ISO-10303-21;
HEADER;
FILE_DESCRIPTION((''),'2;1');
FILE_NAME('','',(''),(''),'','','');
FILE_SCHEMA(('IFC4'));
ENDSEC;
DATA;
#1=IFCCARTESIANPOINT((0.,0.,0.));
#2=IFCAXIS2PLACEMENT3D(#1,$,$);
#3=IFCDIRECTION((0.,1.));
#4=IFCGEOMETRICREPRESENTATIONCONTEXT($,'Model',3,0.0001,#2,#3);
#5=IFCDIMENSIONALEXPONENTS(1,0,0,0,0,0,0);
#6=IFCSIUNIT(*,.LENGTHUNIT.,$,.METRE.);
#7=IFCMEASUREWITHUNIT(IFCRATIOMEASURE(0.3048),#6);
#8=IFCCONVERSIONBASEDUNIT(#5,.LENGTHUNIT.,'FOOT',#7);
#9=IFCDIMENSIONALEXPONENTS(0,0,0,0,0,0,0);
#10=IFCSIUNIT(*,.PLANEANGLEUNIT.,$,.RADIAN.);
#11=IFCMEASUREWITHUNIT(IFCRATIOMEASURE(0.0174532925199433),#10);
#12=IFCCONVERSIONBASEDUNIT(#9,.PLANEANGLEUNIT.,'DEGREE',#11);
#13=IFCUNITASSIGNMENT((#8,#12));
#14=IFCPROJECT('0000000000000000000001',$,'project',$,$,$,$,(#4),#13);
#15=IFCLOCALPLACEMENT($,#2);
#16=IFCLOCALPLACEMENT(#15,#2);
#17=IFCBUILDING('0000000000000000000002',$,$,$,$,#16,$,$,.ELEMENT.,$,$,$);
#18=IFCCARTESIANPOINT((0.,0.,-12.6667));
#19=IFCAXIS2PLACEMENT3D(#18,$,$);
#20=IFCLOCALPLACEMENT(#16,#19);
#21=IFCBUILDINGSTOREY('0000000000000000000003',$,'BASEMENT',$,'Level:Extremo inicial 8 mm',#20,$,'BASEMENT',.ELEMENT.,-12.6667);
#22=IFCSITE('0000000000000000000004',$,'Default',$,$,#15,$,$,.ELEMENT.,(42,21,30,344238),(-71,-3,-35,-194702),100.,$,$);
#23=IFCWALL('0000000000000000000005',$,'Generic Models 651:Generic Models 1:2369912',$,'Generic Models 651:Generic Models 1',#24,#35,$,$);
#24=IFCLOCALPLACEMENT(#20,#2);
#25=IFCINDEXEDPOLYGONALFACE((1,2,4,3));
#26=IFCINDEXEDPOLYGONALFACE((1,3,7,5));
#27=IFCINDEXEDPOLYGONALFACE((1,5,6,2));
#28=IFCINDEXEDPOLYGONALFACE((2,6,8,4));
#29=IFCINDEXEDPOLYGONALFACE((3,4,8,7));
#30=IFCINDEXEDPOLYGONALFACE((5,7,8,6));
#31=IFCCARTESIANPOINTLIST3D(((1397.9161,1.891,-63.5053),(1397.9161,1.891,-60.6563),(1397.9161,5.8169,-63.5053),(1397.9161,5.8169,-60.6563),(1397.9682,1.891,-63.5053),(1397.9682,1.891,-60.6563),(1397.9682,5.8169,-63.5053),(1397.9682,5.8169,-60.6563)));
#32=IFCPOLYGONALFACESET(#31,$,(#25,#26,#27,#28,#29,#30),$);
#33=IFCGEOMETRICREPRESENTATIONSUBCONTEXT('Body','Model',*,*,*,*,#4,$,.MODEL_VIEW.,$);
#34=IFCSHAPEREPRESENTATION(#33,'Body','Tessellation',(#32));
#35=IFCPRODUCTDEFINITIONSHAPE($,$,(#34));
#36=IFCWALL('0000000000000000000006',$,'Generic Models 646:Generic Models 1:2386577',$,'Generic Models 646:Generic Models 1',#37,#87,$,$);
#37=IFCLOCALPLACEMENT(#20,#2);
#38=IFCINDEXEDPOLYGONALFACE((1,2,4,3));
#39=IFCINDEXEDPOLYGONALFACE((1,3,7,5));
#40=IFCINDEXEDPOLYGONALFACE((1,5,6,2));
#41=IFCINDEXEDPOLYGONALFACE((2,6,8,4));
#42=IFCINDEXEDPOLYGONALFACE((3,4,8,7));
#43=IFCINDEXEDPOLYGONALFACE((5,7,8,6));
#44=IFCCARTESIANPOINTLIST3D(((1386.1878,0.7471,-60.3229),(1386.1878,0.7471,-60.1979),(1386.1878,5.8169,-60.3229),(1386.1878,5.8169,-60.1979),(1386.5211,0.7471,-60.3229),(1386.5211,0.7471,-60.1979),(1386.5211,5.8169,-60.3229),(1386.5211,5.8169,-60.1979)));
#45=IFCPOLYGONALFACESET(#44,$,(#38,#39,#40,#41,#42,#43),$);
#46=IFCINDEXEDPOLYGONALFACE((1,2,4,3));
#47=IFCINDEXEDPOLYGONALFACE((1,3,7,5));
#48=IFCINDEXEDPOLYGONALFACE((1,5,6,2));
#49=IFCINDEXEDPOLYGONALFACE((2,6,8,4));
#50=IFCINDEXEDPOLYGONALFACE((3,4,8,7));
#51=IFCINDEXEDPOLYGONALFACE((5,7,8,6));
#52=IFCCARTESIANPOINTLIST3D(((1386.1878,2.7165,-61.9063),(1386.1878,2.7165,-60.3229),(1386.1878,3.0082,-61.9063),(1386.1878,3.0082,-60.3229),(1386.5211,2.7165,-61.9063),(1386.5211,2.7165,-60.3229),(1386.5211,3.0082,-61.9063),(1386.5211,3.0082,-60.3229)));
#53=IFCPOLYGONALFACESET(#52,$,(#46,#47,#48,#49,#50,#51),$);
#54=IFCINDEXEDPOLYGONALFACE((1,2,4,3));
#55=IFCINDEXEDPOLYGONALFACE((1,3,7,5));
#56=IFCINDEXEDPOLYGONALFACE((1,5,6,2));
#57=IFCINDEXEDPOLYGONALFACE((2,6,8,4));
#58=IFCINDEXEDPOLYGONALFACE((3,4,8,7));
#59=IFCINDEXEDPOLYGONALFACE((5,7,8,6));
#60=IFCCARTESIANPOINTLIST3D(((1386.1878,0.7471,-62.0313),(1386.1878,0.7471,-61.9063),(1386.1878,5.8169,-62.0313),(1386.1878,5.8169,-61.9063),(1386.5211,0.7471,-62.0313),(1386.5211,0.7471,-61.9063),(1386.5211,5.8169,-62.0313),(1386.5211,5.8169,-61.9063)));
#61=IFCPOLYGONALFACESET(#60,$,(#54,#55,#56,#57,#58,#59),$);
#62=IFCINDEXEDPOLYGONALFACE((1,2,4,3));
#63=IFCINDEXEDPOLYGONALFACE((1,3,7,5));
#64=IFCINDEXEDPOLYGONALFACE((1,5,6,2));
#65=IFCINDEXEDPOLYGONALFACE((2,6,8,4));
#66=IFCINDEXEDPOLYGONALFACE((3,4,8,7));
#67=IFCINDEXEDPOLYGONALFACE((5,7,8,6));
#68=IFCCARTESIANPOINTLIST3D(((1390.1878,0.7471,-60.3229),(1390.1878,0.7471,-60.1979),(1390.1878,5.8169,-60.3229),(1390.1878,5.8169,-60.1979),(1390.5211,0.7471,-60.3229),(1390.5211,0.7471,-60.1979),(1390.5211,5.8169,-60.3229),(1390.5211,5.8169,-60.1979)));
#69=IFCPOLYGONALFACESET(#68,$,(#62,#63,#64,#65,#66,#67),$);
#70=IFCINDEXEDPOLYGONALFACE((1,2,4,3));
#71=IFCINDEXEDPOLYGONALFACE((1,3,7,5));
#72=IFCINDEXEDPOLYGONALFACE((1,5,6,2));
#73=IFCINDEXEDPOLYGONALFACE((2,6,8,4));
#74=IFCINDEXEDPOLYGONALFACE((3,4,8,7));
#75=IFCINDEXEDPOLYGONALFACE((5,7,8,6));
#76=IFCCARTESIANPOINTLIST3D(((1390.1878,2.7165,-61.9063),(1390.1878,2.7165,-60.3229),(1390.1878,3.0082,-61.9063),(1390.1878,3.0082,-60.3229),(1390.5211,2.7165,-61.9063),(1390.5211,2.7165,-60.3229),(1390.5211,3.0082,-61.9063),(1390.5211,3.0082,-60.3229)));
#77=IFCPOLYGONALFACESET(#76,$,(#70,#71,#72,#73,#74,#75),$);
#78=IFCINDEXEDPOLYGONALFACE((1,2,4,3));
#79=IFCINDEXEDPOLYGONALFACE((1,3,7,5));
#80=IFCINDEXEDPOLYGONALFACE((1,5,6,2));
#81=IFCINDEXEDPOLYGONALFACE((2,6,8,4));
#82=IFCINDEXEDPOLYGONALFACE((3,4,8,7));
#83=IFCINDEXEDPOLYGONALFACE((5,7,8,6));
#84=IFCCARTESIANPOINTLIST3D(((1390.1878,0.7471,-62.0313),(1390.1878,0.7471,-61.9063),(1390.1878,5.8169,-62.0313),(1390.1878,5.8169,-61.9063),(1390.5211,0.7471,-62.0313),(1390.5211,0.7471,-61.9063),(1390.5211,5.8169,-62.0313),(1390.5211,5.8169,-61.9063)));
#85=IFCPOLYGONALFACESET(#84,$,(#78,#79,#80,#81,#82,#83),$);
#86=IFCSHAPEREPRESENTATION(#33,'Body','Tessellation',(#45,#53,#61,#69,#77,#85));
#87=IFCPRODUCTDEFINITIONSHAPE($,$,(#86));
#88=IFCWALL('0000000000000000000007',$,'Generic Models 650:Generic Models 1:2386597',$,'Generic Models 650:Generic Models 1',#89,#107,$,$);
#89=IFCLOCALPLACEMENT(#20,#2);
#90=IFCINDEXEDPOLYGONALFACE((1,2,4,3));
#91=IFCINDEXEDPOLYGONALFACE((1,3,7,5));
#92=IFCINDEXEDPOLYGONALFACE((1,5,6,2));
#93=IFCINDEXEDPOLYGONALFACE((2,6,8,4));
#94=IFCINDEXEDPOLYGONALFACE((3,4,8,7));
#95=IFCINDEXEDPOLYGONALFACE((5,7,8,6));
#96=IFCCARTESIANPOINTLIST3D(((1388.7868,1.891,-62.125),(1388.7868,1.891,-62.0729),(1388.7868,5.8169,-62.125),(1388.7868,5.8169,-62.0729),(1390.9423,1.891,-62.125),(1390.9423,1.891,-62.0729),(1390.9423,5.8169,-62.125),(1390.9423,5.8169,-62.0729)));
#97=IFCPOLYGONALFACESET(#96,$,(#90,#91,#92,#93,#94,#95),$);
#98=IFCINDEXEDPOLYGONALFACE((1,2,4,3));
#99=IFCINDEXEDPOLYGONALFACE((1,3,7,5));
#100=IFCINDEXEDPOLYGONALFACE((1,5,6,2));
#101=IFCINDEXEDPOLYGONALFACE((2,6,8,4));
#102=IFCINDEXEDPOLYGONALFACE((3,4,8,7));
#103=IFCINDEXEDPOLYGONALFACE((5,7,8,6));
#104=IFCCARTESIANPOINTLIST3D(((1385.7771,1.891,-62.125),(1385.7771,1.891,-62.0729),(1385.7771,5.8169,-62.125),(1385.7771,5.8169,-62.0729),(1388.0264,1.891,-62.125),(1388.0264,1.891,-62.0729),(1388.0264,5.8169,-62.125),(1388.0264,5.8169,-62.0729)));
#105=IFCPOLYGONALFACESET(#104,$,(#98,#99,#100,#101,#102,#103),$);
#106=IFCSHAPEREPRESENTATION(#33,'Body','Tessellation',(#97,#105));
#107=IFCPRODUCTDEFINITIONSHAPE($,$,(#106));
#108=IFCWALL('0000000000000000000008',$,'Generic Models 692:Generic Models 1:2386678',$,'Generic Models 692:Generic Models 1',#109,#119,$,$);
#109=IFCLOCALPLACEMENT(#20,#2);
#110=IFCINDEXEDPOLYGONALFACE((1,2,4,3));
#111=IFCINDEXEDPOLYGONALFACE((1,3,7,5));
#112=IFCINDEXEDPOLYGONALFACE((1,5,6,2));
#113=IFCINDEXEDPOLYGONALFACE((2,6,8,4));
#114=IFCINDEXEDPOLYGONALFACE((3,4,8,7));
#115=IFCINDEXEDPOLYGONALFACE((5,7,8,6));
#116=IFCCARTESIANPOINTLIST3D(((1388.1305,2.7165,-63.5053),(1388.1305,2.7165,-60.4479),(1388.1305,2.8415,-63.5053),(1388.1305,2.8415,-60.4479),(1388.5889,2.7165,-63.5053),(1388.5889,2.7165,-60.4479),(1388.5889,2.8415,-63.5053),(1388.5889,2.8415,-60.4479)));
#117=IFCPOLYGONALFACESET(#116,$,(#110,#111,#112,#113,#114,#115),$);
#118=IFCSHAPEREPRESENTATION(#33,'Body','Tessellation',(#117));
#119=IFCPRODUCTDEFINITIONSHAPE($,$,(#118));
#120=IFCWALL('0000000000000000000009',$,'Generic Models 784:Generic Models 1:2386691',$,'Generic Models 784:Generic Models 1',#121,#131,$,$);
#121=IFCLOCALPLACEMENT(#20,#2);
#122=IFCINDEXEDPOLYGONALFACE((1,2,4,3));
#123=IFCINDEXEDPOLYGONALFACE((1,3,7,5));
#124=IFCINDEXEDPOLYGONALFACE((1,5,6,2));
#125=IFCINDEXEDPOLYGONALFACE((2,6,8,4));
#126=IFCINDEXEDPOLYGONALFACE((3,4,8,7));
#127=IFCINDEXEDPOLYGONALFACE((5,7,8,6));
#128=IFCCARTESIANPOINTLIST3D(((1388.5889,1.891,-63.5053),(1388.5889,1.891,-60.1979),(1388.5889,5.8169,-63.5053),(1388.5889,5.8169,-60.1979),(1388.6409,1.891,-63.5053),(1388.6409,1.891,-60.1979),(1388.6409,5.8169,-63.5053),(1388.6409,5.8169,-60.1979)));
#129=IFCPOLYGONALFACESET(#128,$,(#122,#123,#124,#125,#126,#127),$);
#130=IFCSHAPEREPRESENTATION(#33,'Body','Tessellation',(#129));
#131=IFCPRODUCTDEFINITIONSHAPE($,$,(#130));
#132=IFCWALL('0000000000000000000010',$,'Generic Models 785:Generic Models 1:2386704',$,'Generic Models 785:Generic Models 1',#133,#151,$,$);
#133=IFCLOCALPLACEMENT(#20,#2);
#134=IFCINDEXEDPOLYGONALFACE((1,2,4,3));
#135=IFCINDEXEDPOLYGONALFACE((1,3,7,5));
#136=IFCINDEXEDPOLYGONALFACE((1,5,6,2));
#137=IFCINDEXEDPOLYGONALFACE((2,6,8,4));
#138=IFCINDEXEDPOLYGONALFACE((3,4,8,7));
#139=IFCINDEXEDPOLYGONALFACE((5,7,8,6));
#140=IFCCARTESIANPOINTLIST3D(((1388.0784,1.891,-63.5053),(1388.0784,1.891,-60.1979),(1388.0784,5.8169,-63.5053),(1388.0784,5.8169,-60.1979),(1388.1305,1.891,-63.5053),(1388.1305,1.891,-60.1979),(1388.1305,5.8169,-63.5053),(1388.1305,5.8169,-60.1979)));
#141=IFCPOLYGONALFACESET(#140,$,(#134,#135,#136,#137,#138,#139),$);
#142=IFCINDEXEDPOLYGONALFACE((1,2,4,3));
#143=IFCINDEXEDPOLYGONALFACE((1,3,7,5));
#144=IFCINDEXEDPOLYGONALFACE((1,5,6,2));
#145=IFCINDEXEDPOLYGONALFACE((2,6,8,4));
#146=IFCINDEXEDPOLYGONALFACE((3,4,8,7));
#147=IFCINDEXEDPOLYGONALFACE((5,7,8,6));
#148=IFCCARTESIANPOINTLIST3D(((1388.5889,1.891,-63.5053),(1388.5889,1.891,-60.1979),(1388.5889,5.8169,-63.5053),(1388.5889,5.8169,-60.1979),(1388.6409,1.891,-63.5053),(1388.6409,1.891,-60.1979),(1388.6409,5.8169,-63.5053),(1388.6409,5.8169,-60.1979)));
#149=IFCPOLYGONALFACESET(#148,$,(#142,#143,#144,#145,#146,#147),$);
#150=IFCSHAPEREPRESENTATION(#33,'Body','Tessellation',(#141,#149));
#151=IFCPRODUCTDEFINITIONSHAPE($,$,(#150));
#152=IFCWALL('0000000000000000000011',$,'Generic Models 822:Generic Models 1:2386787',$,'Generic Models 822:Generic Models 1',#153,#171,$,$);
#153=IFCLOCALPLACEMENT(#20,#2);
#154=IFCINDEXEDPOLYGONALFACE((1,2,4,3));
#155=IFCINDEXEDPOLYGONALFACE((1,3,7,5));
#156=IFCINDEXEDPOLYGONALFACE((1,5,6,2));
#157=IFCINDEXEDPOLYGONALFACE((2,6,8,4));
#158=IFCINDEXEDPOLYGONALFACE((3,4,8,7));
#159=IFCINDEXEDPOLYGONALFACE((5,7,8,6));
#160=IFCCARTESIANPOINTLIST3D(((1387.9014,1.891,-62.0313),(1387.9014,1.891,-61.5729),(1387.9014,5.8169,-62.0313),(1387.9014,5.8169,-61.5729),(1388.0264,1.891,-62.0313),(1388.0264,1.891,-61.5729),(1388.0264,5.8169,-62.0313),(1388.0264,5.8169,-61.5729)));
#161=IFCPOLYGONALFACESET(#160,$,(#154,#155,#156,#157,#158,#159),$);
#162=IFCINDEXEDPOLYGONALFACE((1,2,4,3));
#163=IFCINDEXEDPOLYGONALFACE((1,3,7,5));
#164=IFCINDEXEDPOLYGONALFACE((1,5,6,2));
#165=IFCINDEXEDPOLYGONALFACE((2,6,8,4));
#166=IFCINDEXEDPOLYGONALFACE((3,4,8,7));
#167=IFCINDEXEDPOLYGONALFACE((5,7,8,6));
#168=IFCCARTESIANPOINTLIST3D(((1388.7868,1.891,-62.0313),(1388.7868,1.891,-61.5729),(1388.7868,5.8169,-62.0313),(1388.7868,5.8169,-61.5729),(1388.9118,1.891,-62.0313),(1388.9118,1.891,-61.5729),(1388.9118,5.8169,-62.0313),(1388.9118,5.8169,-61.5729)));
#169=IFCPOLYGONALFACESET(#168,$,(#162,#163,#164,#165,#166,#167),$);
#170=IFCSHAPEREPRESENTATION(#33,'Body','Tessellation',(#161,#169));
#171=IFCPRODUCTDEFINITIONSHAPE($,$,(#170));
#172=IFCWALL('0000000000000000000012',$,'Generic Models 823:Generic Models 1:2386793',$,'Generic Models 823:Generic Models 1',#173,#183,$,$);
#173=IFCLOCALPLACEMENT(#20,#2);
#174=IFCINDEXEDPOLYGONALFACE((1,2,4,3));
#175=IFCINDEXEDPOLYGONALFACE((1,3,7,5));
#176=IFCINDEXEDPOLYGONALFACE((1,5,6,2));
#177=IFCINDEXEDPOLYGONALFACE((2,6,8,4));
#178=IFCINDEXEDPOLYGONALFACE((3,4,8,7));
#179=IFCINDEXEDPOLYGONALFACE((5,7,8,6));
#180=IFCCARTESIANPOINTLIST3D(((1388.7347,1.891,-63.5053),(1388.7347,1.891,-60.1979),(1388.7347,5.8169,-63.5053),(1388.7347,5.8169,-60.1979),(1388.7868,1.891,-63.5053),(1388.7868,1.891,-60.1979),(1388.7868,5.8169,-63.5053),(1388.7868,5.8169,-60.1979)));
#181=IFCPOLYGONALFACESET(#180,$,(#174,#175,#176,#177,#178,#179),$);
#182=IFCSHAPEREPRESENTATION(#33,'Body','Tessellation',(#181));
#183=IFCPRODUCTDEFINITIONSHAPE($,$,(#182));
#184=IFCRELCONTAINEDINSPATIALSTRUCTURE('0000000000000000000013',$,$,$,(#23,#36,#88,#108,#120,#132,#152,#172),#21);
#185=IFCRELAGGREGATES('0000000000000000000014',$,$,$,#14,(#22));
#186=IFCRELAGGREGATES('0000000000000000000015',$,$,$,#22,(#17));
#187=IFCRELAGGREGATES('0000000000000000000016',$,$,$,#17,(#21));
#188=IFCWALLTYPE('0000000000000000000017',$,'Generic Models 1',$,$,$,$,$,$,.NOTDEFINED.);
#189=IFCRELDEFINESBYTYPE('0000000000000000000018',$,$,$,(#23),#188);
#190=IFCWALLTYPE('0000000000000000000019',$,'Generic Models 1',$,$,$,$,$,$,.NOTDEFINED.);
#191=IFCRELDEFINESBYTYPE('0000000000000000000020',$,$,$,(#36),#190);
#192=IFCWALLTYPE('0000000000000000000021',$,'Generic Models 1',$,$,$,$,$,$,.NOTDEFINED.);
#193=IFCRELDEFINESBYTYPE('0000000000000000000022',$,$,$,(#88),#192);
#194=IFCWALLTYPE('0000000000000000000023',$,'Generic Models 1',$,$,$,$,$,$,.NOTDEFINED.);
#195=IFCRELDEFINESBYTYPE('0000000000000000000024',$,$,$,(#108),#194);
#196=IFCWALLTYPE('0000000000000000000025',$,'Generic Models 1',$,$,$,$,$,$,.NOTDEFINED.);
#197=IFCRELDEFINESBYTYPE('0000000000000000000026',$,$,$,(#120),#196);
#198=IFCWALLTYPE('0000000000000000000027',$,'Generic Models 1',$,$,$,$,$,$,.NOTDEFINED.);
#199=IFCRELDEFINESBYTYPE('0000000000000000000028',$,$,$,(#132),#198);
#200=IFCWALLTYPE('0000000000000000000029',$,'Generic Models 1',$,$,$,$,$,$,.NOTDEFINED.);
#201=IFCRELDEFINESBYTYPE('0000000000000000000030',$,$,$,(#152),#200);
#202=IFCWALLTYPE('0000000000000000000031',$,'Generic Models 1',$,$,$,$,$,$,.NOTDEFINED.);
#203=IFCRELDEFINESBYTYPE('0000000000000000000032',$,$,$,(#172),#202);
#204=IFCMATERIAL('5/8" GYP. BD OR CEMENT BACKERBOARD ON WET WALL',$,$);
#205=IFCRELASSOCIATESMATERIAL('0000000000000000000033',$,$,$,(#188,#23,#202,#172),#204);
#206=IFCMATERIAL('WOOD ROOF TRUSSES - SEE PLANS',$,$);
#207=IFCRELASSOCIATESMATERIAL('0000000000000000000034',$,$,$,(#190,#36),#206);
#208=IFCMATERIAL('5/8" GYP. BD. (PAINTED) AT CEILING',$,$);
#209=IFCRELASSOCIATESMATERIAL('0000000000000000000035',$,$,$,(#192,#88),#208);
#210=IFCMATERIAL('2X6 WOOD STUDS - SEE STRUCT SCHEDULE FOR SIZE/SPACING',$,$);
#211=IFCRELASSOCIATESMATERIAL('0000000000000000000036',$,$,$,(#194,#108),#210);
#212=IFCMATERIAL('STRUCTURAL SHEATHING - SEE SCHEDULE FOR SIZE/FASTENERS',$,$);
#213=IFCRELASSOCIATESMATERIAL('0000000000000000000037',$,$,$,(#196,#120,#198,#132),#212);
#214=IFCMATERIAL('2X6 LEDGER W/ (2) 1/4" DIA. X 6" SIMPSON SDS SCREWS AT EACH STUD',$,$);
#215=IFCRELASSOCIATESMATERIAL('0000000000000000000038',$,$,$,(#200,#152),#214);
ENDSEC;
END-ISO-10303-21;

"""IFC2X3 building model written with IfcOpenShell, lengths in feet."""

from ifc_helpers import new_model, entity, si_unit, converted_unit, direction, frame, frame_2d, origin, place, context, subcontext, project, spatial, rectangle, extrude, material, type_object, element, save


model = new_model("IFC2X3")

# Units and contexts
model_context = context("Model", 3, precision=0.0001, world=origin(), true_north=direction((0.0, 1.0)))
body_context = subcontext(model_context, "Body", "Model", "MODEL_VIEW")
ifc_project = project(units=[converted_unit("LENGTHUNIT", "FOOT", entity("IfcRatioMeasure", 0.3048), si_unit("LENGTHUNIT", "METRE"), dimensions=[1, 0, 0, 0, 0, 0, 0]), converted_unit("PLANEANGLEUNIT", "DEGREE", entity("IfcRatioMeasure", 0.0174532925199433), si_unit("PLANEANGLEUNIT", "RADIAN"), dimensions=[0, 0, 0, 0, 0, 0, 0])], contexts=[model_context])

# Site, building, storey
site_placement = place(None, origin())
site = spatial("IfcSite", under=ifc_project, at=site_placement, Name="Default", CompositionType="ELEMENT", RefLatitude=(42, 21, 30, 344238), RefLongitude=(-71, -3, -35, -194702), RefElevation=100.0)
building_placement = place(site_placement, origin())
building = spatial("IfcBuilding", under=site, at=building_placement, CompositionType="ELEMENT")
storey_placement = place(building_placement, frame((0.0, 0.0, -12.6667)))
storey = spatial("IfcBuildingStorey", under=building, at=storey_placement, Name="BASEMENT", ObjectType="Level:Extremo inicial 8 mm", LongName="BASEMENT", CompositionType="ELEMENT", Elevation=-12.6667)

# Walls
ifc_material_1 = material(Name="2X6 WOOD STUDS - SEE STRUCT SCHEDULE FOR SIZE/SPACING")
ifc_material_2 = material(Name="5/8\" GYP. BD. (PAINTED) AT CEILING")
ifc_material_3 = material(Name="5/8\" GYP. BD OR CEMENT BACKERBOARD ON WET WALL")
wall_type_1 = type_object("IfcWallType", Name="Generic Models 1", PredefinedType="NOTDEFINED", material=ifc_material_3)
wall_1_placement = place(storey_placement, frame((1397.9161, 1.891, -63.5053), z_axis=(0.0, 0.0, 1.0), x_axis=(0.0, 1.0, 0.0)))
element("IfcWall", 1, at=wall_1_placement, inside=storey, type_object=wall_type_1, material=ifc_material_3, Name="Generic Models 651:Generic Models 1:2369912", ObjectType="Generic Models 651:Generic Models 1", context=body_context, shape_type="SweptSolid", body=[
    extrude(rectangle(XDim=3.9258, YDim=0.0521, at=frame_2d((0.0, 0.0), x_axis=(1.0, 0.0))), frame((1.9629, -0.026, 0.0)), (0.0, 0.0, 1.0), 2.849),
])
ifc_material_4 = material(Name="WOOD ROOF TRUSSES - SEE PLANS")
wall_type_2 = type_object("IfcWallType", Name="Generic Models 1", PredefinedType="NOTDEFINED", material=ifc_material_4)
wall_2_placement = place(storey_placement, frame((1386.1878, 0.7471, -62.0313), z_axis=(0.0, 0.0, 1.0), x_axis=(0.0, 1.0, 0.0)))
element("IfcWall", 2, at=wall_2_placement, inside=storey, type_object=wall_type_2, material=ifc_material_4, Name="Generic Models 646:Generic Models 1:2386577", ObjectType="Generic Models 646:Generic Models 1", context=body_context, shape_type="SweptSolid", body=[
    extrude(rectangle(XDim=5.0697, YDim=0.3333, at=frame_2d((0.0, 0.0), x_axis=(1.0, 0.0))), frame((2.5349, -0.1667, 1.7083)), (0.0, 0.0, 1.0), 0.125),
    extrude(rectangle(XDim=0.2917, YDim=0.3333, at=frame_2d((0.0, 0.0), x_axis=(1.0, 0.0))), frame((2.1152, -0.1667, 0.125)), (0.0, 0.0, 1.0), 1.5833),
    extrude(rectangle(XDim=5.0697, YDim=0.3333, at=frame_2d((0.0, 0.0), x_axis=(1.0, 0.0))), frame((2.5349, -0.1667, 0.0)), (0.0, 0.0, 1.0), 0.125),
    extrude(rectangle(XDim=5.0697, YDim=0.3333, at=frame_2d((0.0, 0.0), x_axis=(1.0, 0.0))), frame((2.5349, -4.1667, 1.7083)), (0.0, 0.0, 1.0), 0.125),
    extrude(rectangle(XDim=0.2917, YDim=0.3333, at=frame_2d((0.0, 0.0), x_axis=(1.0, 0.0))), frame((2.1152, -4.1667, 0.125)), (0.0, 0.0, 1.0), 1.5833),
    extrude(rectangle(XDim=5.0697, YDim=0.3333, at=frame_2d((0.0, 0.0), x_axis=(1.0, 0.0))), frame((2.5349, -4.1667, 0.0)), (0.0, 0.0, 1.0), 0.125),
])
wall_type_3 = type_object("IfcWallType", Name="Generic Models 1", PredefinedType="NOTDEFINED", material=ifc_material_2)
wall_3_placement = place(storey_placement, frame((1385.7771, 1.891, -62.125)))
element("IfcWall", 3, at=wall_3_placement, inside=storey, type_object=wall_type_3, material=ifc_material_2, Name="Generic Models 650:Generic Models 1:2386597", ObjectType="Generic Models 650:Generic Models 1", context=body_context, shape_type="SweptSolid", body=[
    extrude(rectangle(XDim=3.9258, YDim=2.1555, at=frame_2d((0.0, 0.0), x_axis=(1.0, 0.0))), frame((4.0875, 1.9629, 0.0), z_axis=(0.0, 0.0, 1.0), x_axis=(0.0, 1.0, 0.0)), (0.0, 0.0, 1.0), 0.0521),
    extrude(rectangle(XDim=3.9258, YDim=2.2493, at=frame_2d((0.0, 0.0), x_axis=(1.0, 0.0))), frame((1.1246, 1.9629, 0.0), z_axis=(0.0, 0.0, 1.0), x_axis=(0.0, 1.0, 0.0)), (0.0, 0.0, 1.0), 0.0521),
])
wall_type_4 = type_object("IfcWallType", Name="Generic Models 1", PredefinedType="NOTDEFINED", material=ifc_material_1)
wall_4_placement = place(storey_placement, frame((1388.1305, 2.7165, -63.5053)))
element("IfcWall", 4, at=wall_4_placement, inside=storey, type_object=wall_type_4, material=ifc_material_1, Name="Generic Models 692:Generic Models 1:2386678", ObjectType="Generic Models 692:Generic Models 1", context=body_context, shape_type="SweptSolid", body=[
    extrude(rectangle(XDim=0.125, YDim=0.4583, at=frame_2d((0.0, 0.0), x_axis=(1.0, 0.0))), frame((0.2292, 0.0625, 0.0), z_axis=(0.0, 0.0, 1.0), x_axis=(0.0, 1.0, 0.0)), (0.0, 0.0, 1.0), 3.0574),
])
ifc_material_5 = material(Name="STRUCTURAL SHEATHING - SEE SCHEDULE FOR SIZE/FASTENERS")
wall_type_5 = type_object("IfcWallType", Name="Generic Models 1", PredefinedType="NOTDEFINED", material=ifc_material_5)
wall_5_placement = place(storey_placement, frame((1388.5889, 1.891, -63.5053), z_axis=(0.0, 0.0, 1.0), x_axis=(0.0, 1.0, 0.0)))
element("IfcWall", 5, at=wall_5_placement, inside=storey, type_object=wall_type_5, material=ifc_material_5, Name="Generic Models 784:Generic Models 1:2386691", ObjectType="Generic Models 784:Generic Models 1", context=body_context, shape_type="SweptSolid", body=[
    extrude(rectangle(XDim=3.9258, YDim=0.0521, at=frame_2d((0.0, 0.0), x_axis=(1.0, 0.0))), frame((1.9629, -0.026, 0.0)), (0.0, 0.0, 1.0), 3.3074),
])
wall_type_6 = type_object("IfcWallType", Name="Generic Models 1", PredefinedType="NOTDEFINED", material=ifc_material_5)
wall_6_placement = place(storey_placement, frame((1388.0784, 1.891, -63.5053), z_axis=(0.0, 0.0, 1.0), x_axis=(0.0, 1.0, 0.0)))
element("IfcWall", 6, at=wall_6_placement, inside=storey, type_object=wall_type_6, material=ifc_material_5, Name="Generic Models 785:Generic Models 1:2386704", ObjectType="Generic Models 785:Generic Models 1", context=body_context, shape_type="SweptSolid", body=[
    extrude(rectangle(XDim=3.9258, YDim=0.0521, at=frame_2d((0.0, 0.0), x_axis=(1.0, 0.0))), frame((1.9629, -0.026, 0.0)), (0.0, 0.0, 1.0), 3.3074),
    extrude(rectangle(XDim=3.9258, YDim=0.0521, at=frame_2d((0.0, 0.0), x_axis=(1.0, 0.0))), frame((1.9629, -0.5365, 0.0)), (0.0, 0.0, 1.0), 3.3074),
])
ifc_material_6 = material(Name="2X6 LEDGER W/ (2) 1/4\" DIA. X 6\" SIMPSON SDS SCREWS AT EACH STUD")
wall_type_7 = type_object("IfcWallType", Name="Generic Models 1", PredefinedType="NOTDEFINED", material=ifc_material_6)
wall_7_placement = place(storey_placement, frame((1387.9014, 1.891, -62.0313), z_axis=(0.0, 0.0, 1.0), x_axis=(0.0, 1.0, 0.0)))
element("IfcWall", 7, at=wall_7_placement, inside=storey, type_object=wall_type_7, material=ifc_material_6, Name="Generic Models 822:Generic Models 1:2386787", ObjectType="Generic Models 822:Generic Models 1", context=body_context, shape_type="SweptSolid", body=[
    extrude(rectangle(XDim=3.9258, YDim=0.125, at=frame_2d((0.0, 0.0), x_axis=(1.0, 0.0))), frame((1.9629, -0.0625, 0.0)), (0.0, 0.0, 1.0), 0.4583),
    extrude(rectangle(XDim=3.9258, YDim=0.125, at=frame_2d((0.0, 0.0), x_axis=(1.0, 0.0))), frame((1.9629, -0.9479, 0.0)), (0.0, 0.0, 1.0), 0.4583),
])
wall_type_8 = type_object("IfcWallType", Name="Generic Models 1", PredefinedType="NOTDEFINED", material=ifc_material_3)
wall_8_placement = place(storey_placement, frame((1388.7347, 1.891, -63.5053), z_axis=(0.0, 0.0, 1.0), x_axis=(0.0, 1.0, 0.0)))
element("IfcWall", 8, at=wall_8_placement, inside=storey, type_object=wall_type_8, material=ifc_material_3, Name="Generic Models 823:Generic Models 1:2386793", ObjectType="Generic Models 823:Generic Models 1", context=body_context, shape_type="SweptSolid", body=[
    extrude(rectangle(XDim=3.9258, YDim=0.0521, at=frame_2d((0.0, 0.0), x_axis=(1.0, 0.0))), frame((1.9629, -0.026, 0.0)), (0.0, 0.0, 1.0), 3.3074),
])

save(model, "model.ifc")
